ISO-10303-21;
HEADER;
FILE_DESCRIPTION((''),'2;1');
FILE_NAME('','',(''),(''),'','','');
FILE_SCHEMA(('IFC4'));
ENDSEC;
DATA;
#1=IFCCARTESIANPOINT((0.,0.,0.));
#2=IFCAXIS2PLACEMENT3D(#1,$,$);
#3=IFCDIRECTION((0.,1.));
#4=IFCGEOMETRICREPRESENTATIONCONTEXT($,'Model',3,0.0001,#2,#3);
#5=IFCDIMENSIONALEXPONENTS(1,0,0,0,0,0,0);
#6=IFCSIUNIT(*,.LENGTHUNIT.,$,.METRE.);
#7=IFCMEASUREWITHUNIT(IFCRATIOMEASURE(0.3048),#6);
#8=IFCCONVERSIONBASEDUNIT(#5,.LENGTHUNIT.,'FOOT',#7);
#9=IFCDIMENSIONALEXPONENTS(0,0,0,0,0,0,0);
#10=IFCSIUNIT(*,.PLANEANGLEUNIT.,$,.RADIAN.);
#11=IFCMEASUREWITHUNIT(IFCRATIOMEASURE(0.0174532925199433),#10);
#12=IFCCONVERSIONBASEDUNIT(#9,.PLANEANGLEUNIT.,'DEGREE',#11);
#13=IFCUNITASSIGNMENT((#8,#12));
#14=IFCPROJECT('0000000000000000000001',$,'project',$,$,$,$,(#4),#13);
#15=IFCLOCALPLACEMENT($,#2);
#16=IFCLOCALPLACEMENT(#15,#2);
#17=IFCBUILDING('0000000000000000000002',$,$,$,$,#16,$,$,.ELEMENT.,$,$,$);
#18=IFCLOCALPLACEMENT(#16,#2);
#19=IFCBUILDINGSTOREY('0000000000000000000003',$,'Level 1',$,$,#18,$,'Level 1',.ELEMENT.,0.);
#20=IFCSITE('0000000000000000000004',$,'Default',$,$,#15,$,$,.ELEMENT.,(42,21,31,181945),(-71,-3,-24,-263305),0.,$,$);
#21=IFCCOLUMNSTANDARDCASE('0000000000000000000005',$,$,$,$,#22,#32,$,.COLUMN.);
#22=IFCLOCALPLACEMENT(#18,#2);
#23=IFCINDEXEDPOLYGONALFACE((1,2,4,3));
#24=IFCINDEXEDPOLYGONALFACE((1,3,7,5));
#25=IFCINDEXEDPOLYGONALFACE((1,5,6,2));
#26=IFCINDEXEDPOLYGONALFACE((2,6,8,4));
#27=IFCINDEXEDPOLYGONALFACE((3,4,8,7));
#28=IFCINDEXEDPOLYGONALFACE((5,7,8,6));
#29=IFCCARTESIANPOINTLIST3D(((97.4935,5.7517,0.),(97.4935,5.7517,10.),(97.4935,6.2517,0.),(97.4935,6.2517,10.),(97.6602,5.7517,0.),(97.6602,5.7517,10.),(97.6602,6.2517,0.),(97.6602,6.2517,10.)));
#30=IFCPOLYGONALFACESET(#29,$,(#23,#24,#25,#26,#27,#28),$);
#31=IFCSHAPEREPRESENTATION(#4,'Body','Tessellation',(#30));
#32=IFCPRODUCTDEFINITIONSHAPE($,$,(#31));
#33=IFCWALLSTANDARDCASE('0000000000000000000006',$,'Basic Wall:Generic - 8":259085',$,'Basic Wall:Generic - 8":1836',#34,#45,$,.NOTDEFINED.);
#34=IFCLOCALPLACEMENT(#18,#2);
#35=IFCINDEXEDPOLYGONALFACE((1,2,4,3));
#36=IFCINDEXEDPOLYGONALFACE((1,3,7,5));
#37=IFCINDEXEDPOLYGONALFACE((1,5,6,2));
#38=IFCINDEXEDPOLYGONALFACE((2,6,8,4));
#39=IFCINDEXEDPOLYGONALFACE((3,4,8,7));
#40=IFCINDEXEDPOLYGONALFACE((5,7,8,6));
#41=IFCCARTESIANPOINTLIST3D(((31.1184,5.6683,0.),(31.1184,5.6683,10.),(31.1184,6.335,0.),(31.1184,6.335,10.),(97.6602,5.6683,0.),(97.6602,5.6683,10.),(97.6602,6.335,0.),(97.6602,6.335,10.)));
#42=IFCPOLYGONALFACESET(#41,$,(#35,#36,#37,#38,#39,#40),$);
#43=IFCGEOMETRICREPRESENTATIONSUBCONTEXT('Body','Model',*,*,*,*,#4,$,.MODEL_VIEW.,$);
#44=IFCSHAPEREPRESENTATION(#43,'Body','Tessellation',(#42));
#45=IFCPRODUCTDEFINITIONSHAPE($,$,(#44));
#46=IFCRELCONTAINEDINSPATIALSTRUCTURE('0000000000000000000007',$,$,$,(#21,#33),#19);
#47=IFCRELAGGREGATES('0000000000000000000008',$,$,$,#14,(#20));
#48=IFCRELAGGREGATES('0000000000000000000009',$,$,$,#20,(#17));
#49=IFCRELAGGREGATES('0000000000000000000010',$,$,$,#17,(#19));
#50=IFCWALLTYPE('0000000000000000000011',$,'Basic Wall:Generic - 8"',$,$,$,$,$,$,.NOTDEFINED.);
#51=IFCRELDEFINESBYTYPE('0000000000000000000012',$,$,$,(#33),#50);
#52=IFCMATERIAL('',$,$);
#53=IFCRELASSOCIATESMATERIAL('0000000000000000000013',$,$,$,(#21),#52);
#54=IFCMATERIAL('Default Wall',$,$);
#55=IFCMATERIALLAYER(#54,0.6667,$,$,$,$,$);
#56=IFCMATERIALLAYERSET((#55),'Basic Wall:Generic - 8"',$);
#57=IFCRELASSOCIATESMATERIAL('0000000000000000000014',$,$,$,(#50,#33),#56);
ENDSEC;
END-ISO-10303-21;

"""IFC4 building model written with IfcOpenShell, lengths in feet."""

from ifc_helpers import new_model, entity, si_unit, converted_unit, direction, frame, frame_2d, origin, place, context, subcontext, project, spatial, rectangle, extrude, material, layer, layer_set, layer_usage, type_object, element, save


model = new_model("IFC4")

# Units and contexts
model_context = context("Model", 3, precision=0.0001, world=origin(), true_north=direction((0.0, 1.0)))
body_context = subcontext(model_context, "Body", "Model", "MODEL_VIEW")
ifc_project = project(units=[converted_unit("LENGTHUNIT", "FOOT", entity("IfcRatioMeasure", 0.3048), si_unit("LENGTHUNIT", "METRE"), dimensions=[1, 0, 0, 0, 0, 0, 0]), converted_unit("PLANEANGLEUNIT", "DEGREE", entity("IfcRatioMeasure", 0.0174532925199433), si_unit("PLANEANGLEUNIT", "RADIAN"), dimensions=[0, 0, 0, 0, 0, 0, 0])], contexts=[model_context])

# Site, building, storey
site_placement = place(None, origin())
site = spatial("IfcSite", under=ifc_project, at=site_placement, Name="Default", CompositionType="ELEMENT", RefLatitude=(42, 21, 31, 181945), RefLongitude=(-71, -3, -24, -263305), RefElevation=0.0)
building_placement = place(site_placement, origin())
building = spatial("IfcBuilding", under=site, at=building_placement, CompositionType="ELEMENT")
storey_placement = place(building_placement, origin())
storey = spatial("IfcBuildingStorey", under=building, at=storey_placement, Name="Level 1", LongName="Level 1", CompositionType="ELEMENT", Elevation=0.0)

# Column
ifc_material_1 = material(Name="")
wall_placement = place(storey_placement, frame((97.6602, 6.0017, 0.0), z_axis=(0.0, 0.0, 1.0), x_axis=(-1.0, 0.0, 0.0)))
column_placement = place(wall_placement, frame((0.0833, 0.0, 0.0), z_axis=(0.0, 0.0, 1.0), x_axis=(1.0, 0.0, 0.0)))
element("IfcColumnStandardCase", 1, at=column_placement, inside=storey, material=ifc_material_1, PredefinedType="COLUMN", context=model_context, shape_type="SweptSolid", body=[
    extrude(rectangle(XDim=0.1667, YDim=0.5), origin(), (0.0, 0.0, 1.0), 10.0),
])

# Wall
ifc_material_2 = material(Name="Default Wall")
ifc_layer = layer(ifc_material_2, 0.6667)
ifc_layer_set = layer_set([ifc_layer], Name="Basic Wall:Generic - 8\"")
ifc_layer_usage = layer_usage(ifc_layer_set, "AXIS2", "NEGATIVE", 0.3333)
wall_type = type_object("IfcWallType", Name="Basic Wall:Generic - 8\"", PredefinedType="NOTDEFINED", material=ifc_layer_set)
element("IfcWallStandardCase", 2, at=wall_placement, inside=storey, type_object=wall_type, material=ifc_layer_usage, Name="Basic Wall:Generic - 8\":259085", ObjectType="Basic Wall:Generic - 8\":1836", PredefinedType="NOTDEFINED", context=body_context, shape_type="SweptSolid", body=[
    extrude(rectangle(XDim=66.5419, YDim=0.6667, at=frame_2d((33.2709, 0.0), x_axis=(-1.0, 0.0))), origin(), (0.0, 0.0, 1.0), 10.0),
])

save(model, "model.ifc")
